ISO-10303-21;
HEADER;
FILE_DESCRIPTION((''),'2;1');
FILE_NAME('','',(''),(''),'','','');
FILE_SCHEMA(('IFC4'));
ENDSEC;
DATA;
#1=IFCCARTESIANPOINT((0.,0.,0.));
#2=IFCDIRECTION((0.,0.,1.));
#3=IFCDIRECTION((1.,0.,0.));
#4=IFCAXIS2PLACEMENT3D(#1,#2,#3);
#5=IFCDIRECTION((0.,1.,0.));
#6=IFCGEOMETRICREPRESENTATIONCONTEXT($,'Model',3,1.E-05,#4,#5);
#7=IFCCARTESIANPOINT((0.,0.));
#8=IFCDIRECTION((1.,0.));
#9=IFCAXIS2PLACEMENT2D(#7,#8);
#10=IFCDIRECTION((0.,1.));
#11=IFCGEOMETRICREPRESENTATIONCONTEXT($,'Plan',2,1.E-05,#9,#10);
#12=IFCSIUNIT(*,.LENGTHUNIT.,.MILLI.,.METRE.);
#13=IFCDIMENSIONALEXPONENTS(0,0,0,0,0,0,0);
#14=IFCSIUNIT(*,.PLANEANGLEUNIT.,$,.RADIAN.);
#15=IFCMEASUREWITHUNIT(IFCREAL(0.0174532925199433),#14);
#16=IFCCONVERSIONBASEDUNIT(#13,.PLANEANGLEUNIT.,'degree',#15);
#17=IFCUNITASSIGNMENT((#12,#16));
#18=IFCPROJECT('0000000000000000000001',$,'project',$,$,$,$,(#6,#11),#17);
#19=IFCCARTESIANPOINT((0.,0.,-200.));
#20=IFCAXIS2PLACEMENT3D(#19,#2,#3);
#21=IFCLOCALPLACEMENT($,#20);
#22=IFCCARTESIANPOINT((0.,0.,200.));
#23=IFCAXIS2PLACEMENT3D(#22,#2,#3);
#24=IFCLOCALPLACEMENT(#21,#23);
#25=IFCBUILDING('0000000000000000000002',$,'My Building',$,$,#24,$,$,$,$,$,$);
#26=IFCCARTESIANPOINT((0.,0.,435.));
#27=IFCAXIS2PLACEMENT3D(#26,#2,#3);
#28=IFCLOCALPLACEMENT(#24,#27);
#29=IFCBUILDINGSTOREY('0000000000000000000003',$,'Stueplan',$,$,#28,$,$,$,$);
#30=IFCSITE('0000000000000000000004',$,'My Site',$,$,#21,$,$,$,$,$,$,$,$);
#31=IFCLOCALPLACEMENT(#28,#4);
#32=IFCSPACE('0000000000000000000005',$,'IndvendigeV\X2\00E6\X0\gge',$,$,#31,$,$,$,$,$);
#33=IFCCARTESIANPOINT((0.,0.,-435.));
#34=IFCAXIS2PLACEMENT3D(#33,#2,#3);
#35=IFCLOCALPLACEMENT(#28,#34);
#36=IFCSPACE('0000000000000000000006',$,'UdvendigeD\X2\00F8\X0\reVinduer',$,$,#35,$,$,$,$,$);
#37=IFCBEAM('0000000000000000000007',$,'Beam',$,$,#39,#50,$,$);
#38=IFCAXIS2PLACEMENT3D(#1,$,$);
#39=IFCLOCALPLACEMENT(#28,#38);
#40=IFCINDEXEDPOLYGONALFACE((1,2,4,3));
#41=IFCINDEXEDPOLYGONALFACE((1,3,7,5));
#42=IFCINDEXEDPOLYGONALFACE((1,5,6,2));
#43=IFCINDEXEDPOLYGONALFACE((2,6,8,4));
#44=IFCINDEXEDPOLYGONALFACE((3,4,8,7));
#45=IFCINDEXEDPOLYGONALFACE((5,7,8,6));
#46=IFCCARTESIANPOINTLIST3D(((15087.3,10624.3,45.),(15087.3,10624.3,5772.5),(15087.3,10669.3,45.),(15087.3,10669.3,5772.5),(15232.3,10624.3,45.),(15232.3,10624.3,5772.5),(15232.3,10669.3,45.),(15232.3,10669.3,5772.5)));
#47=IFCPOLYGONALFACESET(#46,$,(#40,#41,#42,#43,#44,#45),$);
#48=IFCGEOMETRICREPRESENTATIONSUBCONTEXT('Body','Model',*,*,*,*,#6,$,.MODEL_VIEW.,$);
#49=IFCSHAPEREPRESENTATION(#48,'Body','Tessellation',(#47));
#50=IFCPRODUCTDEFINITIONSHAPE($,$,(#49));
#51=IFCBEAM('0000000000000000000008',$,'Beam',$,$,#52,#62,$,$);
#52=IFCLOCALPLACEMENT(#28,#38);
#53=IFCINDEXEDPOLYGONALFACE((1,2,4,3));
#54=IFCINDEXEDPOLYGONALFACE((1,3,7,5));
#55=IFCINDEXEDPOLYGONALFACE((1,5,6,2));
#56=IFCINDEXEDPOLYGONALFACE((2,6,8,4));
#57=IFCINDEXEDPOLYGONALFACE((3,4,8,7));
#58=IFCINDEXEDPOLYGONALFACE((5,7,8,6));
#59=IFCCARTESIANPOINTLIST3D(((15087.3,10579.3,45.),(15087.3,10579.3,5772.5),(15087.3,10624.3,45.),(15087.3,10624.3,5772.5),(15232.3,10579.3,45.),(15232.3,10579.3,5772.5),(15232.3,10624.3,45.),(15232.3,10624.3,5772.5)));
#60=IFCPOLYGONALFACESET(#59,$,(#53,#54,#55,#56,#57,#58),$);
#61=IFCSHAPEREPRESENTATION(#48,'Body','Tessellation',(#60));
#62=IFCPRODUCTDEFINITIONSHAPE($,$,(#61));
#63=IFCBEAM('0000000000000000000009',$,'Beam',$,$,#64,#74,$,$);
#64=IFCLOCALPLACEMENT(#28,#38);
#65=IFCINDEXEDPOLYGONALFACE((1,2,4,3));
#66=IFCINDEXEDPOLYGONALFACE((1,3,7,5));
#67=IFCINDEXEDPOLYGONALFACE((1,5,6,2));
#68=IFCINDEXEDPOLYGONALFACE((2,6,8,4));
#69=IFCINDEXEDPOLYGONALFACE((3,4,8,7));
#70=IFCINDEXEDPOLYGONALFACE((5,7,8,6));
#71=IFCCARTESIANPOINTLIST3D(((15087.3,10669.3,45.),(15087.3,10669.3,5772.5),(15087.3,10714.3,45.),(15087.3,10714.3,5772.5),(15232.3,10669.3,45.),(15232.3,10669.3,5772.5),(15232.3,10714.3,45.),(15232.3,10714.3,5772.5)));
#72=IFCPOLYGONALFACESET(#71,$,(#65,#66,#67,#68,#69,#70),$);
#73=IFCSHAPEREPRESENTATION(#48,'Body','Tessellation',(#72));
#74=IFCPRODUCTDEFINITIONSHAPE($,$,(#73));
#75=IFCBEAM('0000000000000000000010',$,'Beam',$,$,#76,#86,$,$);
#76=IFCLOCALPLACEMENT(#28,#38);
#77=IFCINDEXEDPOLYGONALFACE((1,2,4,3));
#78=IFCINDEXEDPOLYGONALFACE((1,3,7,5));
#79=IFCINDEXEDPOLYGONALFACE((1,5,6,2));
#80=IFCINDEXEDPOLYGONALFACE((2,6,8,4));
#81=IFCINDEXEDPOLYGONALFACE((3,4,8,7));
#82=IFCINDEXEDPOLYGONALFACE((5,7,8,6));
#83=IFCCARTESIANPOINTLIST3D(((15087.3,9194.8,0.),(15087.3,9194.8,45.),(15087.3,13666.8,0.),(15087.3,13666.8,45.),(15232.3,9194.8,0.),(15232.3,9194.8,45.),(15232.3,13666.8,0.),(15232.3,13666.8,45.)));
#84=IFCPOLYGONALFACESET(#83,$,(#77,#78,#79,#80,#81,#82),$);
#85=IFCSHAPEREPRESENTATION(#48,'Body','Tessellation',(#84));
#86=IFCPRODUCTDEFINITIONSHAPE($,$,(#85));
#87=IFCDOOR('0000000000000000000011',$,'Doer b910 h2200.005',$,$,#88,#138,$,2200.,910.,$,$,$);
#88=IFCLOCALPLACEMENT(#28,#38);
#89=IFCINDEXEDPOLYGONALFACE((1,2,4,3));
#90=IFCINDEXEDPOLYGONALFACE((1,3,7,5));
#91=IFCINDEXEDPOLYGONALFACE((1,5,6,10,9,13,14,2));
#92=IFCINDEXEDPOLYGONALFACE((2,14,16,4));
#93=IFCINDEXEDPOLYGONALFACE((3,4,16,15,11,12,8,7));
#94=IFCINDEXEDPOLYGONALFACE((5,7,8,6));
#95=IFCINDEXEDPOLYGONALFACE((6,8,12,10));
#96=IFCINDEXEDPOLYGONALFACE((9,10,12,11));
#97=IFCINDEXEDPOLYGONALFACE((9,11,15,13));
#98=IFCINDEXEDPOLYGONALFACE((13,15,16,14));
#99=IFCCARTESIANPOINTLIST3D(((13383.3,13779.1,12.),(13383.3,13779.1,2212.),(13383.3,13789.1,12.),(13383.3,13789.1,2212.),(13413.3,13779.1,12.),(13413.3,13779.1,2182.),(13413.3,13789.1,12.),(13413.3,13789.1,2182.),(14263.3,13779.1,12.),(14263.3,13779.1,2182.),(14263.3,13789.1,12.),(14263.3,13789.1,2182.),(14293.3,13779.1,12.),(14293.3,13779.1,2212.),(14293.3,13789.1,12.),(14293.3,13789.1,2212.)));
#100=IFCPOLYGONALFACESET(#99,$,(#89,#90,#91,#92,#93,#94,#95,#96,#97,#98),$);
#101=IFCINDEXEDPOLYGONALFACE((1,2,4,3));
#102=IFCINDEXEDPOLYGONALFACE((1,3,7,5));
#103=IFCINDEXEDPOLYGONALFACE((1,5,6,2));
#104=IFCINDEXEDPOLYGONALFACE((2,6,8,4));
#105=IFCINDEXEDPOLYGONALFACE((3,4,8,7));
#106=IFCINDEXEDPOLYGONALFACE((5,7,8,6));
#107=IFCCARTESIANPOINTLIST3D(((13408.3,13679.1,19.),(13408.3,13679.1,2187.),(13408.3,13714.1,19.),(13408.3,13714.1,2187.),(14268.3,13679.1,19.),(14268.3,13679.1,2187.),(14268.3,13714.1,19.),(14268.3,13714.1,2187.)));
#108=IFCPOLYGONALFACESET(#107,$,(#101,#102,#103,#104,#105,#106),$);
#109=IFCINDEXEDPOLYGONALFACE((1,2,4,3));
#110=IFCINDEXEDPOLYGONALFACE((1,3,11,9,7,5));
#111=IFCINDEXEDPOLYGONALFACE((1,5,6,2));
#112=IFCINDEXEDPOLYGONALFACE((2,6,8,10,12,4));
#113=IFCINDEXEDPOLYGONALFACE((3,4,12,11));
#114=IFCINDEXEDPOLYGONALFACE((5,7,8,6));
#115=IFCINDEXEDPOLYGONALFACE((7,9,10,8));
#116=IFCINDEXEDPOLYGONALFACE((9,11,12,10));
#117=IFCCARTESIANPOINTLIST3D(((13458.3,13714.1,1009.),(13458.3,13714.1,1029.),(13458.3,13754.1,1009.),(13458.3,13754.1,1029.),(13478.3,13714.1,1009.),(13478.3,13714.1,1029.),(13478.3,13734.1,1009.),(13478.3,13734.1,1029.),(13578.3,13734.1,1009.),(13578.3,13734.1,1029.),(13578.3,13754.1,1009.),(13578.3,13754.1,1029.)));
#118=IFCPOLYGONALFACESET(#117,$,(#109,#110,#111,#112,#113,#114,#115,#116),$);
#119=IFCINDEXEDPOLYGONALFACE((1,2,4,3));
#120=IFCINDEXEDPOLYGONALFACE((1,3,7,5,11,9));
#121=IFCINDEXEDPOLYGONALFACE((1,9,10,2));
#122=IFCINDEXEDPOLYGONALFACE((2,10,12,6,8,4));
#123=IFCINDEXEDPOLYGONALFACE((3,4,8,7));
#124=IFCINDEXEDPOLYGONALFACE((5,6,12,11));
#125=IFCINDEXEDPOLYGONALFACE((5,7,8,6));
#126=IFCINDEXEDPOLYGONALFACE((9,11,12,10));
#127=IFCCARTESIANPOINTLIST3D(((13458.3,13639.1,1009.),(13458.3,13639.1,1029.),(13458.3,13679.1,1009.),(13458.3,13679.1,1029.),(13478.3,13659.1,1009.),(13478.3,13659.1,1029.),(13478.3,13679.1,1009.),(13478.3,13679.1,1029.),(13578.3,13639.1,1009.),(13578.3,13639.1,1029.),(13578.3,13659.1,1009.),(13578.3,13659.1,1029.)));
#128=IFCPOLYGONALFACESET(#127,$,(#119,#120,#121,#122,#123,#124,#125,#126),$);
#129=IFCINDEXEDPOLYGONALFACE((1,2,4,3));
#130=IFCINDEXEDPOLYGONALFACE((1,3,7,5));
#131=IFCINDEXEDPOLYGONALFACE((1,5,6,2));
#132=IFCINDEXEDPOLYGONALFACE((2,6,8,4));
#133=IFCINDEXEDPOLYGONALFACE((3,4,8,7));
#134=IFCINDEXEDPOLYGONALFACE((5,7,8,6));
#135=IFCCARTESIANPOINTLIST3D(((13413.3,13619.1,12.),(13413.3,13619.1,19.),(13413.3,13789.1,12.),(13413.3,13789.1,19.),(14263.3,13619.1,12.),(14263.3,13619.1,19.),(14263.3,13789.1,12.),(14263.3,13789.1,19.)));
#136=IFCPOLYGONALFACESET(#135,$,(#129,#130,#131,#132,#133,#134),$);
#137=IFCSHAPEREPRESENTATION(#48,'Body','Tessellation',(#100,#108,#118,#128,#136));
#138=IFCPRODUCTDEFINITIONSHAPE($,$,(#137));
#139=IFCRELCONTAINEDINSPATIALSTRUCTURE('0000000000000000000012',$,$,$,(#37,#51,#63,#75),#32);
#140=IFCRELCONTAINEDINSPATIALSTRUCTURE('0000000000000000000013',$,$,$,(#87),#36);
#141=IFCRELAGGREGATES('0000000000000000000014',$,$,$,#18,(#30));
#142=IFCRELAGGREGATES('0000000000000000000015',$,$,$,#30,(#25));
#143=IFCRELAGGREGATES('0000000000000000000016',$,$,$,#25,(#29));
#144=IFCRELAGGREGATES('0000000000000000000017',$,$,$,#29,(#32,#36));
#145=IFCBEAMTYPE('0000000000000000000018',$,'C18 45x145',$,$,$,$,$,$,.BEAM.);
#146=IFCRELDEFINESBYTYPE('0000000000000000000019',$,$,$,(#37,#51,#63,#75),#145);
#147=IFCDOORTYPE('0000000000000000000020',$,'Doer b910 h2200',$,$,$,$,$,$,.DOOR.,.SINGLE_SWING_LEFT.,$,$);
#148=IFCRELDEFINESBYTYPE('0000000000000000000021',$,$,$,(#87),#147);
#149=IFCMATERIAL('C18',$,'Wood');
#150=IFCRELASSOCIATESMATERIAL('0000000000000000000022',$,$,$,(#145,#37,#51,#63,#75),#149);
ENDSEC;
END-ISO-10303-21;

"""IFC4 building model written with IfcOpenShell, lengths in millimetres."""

from ifc_helpers import new_model, entity, si_unit, converted_unit, direction, frame, origin_with_axes, origin_2d_with_axis, place, context, subcontext, project, spatial, line, indexed_curve, rectangle, outline, extrude, shape, source, transform, mapped, material, material_profile, profile_set, profile_usage, type_object, type_shapes, element, save


model = new_model("IFC4")

# Units and contexts
model_context = context("Model", 3, precision=1e-05, world=origin_with_axes(), true_north=direction((0.0, 1.0, 0.0)))
plan_context = context("Plan", 2, precision=1e-05, world=origin_2d_with_axis(), true_north=direction((0.0, 1.0)))
body_context_1 = subcontext(model_context, "Body", "Model", "MODEL_VIEW")
body_context_2 = subcontext(plan_context, "Body", "Plan", "PLAN_VIEW")
ifc_project = project(units=[si_unit("LENGTHUNIT", "METRE", prefix="MILLI"), converted_unit("PLANEANGLEUNIT", "degree", entity("IfcReal", 0.0174532925199433), si_unit("PLANEANGLEUNIT", "RADIAN"), dimensions=[0, 0, 0, 0, 0, 0, 0])], contexts=[model_context, plan_context])

# Site, building, storey
site_placement = place(None, frame((0.0, 0.0, -200.0), z_axis=(0.0, 0.0, 1.0), x_axis=(1.0, 0.0, 0.0)))
site = spatial("IfcSite", under=ifc_project, at=site_placement, Name="My Site")
building_placement = place(site_placement, frame((0.0, 0.0, 200.0), z_axis=(0.0, 0.0, 1.0), x_axis=(1.0, 0.0, 0.0)))
building = spatial("IfcBuilding", under=site, at=building_placement, Name="My Building")
storey_placement = place(building_placement, frame((0.0, 0.0, 435.0), z_axis=(0.0, 0.0, 1.0), x_axis=(1.0, 0.0, 0.0)))
storey = spatial("IfcBuildingStorey", under=building, at=storey_placement, Name="Stueplan")

# Shared definitions
ifc_material = material(Name="C18", Category="Wood")

# Shared definitions
space_1_placement = place(storey_placement, frame((0.0, 0.0, 0.0), z_axis=(0.0, 0.0, 1.0), x_axis=(1.0, 0.0, 0.0)))
space_1 = spatial("IfcSpace", under=storey, at=space_1_placement, Name="IndvendigeVægge")

# Beams
ifc_material_profile_1 = material_profile(ifc_material, rectangle(XDim=45.0, YDim=145.0))
ifc_profile_set_1 = profile_set([ifc_material_profile_1], Name="woodStructural")
beam_type_1 = type_object("IfcBeamType", Name="C18 45x145", PredefinedType="BEAM", material=ifc_profile_set_1)
ifc_profile_usage_1 = profile_usage(ifc_profile_set_1)
beam_1_placement = place(space_1_placement, frame((15159.8, 10646.8, 45.0), z_axis=(0.0, 0.0, 1.0), x_axis=(0.0, -1.0, 0.0)))
element("IfcBeam", 1, at=beam_1_placement, inside=space_1, type_object=beam_type_1, material=ifc_profile_usage_1, Name="Beam", context=body_context_1, shape_type="SweptSolid", body=[
    extrude(rectangle(XDim=45.0, YDim=145.0), origin_with_axes(), (0.0, 0.0, 1.0), 5727.5),
])
ifc_profile_usage_2 = profile_usage(ifc_profile_set_1)
beam_2_placement = place(space_1_placement, frame((15159.8, 10601.8, 45.0), z_axis=(0.0, 0.0, 1.0), x_axis=(0.0, -1.0, 0.0)))
element("IfcBeam", 2, at=beam_2_placement, inside=space_1, type_object=beam_type_1, material=ifc_profile_usage_2, Name="Beam", context=body_context_1, shape_type="SweptSolid", body=[
    extrude(rectangle(XDim=45.0, YDim=145.0), origin_with_axes(), (0.0, 0.0, 1.0), 5727.5),
])
ifc_profile_usage_3 = profile_usage(ifc_profile_set_1)
beam_3_placement = place(space_1_placement, frame((15159.8, 10691.8, 45.0), z_axis=(0.0, 0.0, 1.0), x_axis=(0.0, -1.0, 0.0)))
element("IfcBeam", 3, at=beam_3_placement, inside=space_1, type_object=beam_type_1, material=ifc_profile_usage_3, Name="Beam", context=body_context_1, shape_type="SweptSolid", body=[
    extrude(rectangle(XDim=45.0, YDim=145.0), origin_with_axes(), (0.0, 0.0, 1.0), 5727.5),
])
ifc_profile_usage_4 = profile_usage(ifc_profile_set_1)
beam_4_placement = place(space_1_placement, frame((15159.8, 13666.8, 22.5), z_axis=(0.0, -1.0, 0.0), x_axis=(0.0, 0.0, -1.0)))
element("IfcBeam", 4, at=beam_4_placement, inside=space_1, type_object=beam_type_1, material=ifc_profile_usage_4, Name="Beam", context=body_context_1, shape_type="SweptSolid", body=[
    extrude(rectangle(XDim=45.0, YDim=145.0), origin_with_axes(), (0.0, 0.0, 1.0), 4472.0),
])

# Shared definitions
space_2_placement = place(storey_placement, frame((0.0, 0.0, -435.0), z_axis=(0.0, 0.0, 1.0), x_axis=(1.0, 0.0, 0.0)))
space_2 = spatial("IfcSpace", under=storey, at=space_2_placement, Name="UdvendigeDøreVinduer")

# Door
door_type = type_object("IfcDoorType", Name="Doer b910 h2200", OperationType="SINGLE_SWING_LEFT", PredefinedType="DOOR")
shared_shape_1 = source(origin_with_axes(), body_context_1, "Body", "SweptSolid", [
    extrude(outline(indexed_curve([(0.0, 0.0), (0.0, 2200.0), (910.0, 2200.0), (910.0, 0.0), (880.0, 0.0), (880.0, 2170.0), (30.0, 2170.0), (30.0, 0.0)], segments=[line(1, 2, 3, 4, 5, 6, 7, 8, 1)])), frame((0.0, 0.0, 0.0), z_axis=(0.0, -1.0, 0.0), x_axis=(1.0, 0.0, 0.0)), (0.0, 0.0, -1.0), 10.0),
    extrude(outline(indexed_curve([(0.0, 0.0), (860.0, 0.0), (860.0, 35.0), (0.0, 35.0)], segments=[line(1, 2, 3, 4, 1)])), frame((25.0, 75.0, 7.0), z_axis=(0.0, 0.0, 1.0), x_axis=(1.0, 0.0, 0.0)), (0.0, 0.0, 1.0), 2168.0),
    extrude(outline(indexed_curve([(0.0, 0.0), (0.0, -40.0), (-120.0, -40.0), (-120.0, -20.0), (-20.0, -20.0), (-20.0, 0.0)], segments=[line(1, 2, 3, 4, 5, 6, 1)])), frame((835.0, 75.0, 997.0), z_axis=(0.0, 0.0, 1.0), x_axis=(1.0, 0.0, 0.0)), (0.0, 0.0, 1.0), 20.0),
    extrude(outline(indexed_curve([(0.0, 0.0), (0.0, 40.0), (-120.0, 40.0), (-120.0, 20.0), (-20.0, 20.0), (-20.0, 0.0)], segments=[line(1, 2, 3, 4, 5, 6, 1)])), frame((835.0, 110.0, 997.0), z_axis=(0.0, 0.0, 1.0), x_axis=(1.0, 0.0, 0.0)), (0.0, 0.0, 1.0), 20.0),
    extrude(outline(indexed_curve([(0.0, 0.0), (850.0, 0.0), (850.0, 170.0), (0.0, 170.0)], segments=[line(1, 2, 3, 4, 1)])), frame((30.0, 0.0, 0.0), z_axis=(0.0, 0.0, 1.0), x_axis=(1.0, 0.0, 0.0)), (0.0, 0.0, 1.0), 7.0),
])
shared_shape_2 = source(origin_with_axes(), body_context_2, "Body", "Curve2D", [
    entity("IfcIndexedPolyCurve", entity("IfcCartesianPointList2D", [[0.0, 0.0], [30.0, 0.0], [30.0, 10.0], [0.0, 10.0]]), [entity("IfcLineIndex", [1, 2, 3, 4, 1])]),
    entity("IfcIndexedPolyCurve", entity("IfcCartesianPointList2D", [[910.0, 0.0], [880.0, 0.0], [880.0, 10.0], [910.0, 10.0]]), [entity("IfcLineIndex", [1, 2, 3, 4, 1])]),
    entity("IfcTrimmedCurve", entity("IfcEllipse", entity("IfcAxis2Placement2D", entity("IfcCartesianPoint", [60.0, 10.0]), entity("IfcDirection", [1.0, 0.0])), 825.0, 860.0), [entity("IfcCartesianPoint", [885.0, 10.0])], [entity("IfcCartesianPoint", [60.0, 870.0])], True, "CARTESIAN"),
    entity("IfcIndexedPolyCurve", entity("IfcCartesianPointList2D", [[25.0, 10.0], [60.0, 10.0], [60.0, 870.0], [25.0, 870.0]]), [entity("IfcLineIndex", [1, 2, 3, 4, 1])]),
])
type_shapes(door_type, [shared_shape_1, shared_shape_2])
door_placement = place(space_2_placement, frame((14293.3, 13789.1, 447.0), z_axis=(0.0, 0.0, 1.0), x_axis=(-1.0, 0.0, 0.0)))
element("IfcDoor", 5, at=door_placement, inside=space_2, type_object=door_type, Name="Doer b910 h2200.005", OverallHeight=2200.0, OverallWidth=910.0, shapes=[
    shape(body_context_1, "Body", "MappedRepresentation", [mapped(shared_shape_1, transform((0.0, 0.0, 0.0), x_axis=(1.0, 0.0, 0.0), y_axis=(0.0, 1.0, 0.0), z_axis=(0.0, 0.0, 1.0), scale=1.0))]),
    shape(body_context_2, "Body", "MappedRepresentation", [mapped(shared_shape_2, transform((0.0, 0.0, 0.0), x_axis=(1.0, 0.0, 0.0), y_axis=(0.0, 1.0, 0.0), z_axis=(0.0, 0.0, 1.0), scale=1.0))]),
])

save(model, "model.ifc")
